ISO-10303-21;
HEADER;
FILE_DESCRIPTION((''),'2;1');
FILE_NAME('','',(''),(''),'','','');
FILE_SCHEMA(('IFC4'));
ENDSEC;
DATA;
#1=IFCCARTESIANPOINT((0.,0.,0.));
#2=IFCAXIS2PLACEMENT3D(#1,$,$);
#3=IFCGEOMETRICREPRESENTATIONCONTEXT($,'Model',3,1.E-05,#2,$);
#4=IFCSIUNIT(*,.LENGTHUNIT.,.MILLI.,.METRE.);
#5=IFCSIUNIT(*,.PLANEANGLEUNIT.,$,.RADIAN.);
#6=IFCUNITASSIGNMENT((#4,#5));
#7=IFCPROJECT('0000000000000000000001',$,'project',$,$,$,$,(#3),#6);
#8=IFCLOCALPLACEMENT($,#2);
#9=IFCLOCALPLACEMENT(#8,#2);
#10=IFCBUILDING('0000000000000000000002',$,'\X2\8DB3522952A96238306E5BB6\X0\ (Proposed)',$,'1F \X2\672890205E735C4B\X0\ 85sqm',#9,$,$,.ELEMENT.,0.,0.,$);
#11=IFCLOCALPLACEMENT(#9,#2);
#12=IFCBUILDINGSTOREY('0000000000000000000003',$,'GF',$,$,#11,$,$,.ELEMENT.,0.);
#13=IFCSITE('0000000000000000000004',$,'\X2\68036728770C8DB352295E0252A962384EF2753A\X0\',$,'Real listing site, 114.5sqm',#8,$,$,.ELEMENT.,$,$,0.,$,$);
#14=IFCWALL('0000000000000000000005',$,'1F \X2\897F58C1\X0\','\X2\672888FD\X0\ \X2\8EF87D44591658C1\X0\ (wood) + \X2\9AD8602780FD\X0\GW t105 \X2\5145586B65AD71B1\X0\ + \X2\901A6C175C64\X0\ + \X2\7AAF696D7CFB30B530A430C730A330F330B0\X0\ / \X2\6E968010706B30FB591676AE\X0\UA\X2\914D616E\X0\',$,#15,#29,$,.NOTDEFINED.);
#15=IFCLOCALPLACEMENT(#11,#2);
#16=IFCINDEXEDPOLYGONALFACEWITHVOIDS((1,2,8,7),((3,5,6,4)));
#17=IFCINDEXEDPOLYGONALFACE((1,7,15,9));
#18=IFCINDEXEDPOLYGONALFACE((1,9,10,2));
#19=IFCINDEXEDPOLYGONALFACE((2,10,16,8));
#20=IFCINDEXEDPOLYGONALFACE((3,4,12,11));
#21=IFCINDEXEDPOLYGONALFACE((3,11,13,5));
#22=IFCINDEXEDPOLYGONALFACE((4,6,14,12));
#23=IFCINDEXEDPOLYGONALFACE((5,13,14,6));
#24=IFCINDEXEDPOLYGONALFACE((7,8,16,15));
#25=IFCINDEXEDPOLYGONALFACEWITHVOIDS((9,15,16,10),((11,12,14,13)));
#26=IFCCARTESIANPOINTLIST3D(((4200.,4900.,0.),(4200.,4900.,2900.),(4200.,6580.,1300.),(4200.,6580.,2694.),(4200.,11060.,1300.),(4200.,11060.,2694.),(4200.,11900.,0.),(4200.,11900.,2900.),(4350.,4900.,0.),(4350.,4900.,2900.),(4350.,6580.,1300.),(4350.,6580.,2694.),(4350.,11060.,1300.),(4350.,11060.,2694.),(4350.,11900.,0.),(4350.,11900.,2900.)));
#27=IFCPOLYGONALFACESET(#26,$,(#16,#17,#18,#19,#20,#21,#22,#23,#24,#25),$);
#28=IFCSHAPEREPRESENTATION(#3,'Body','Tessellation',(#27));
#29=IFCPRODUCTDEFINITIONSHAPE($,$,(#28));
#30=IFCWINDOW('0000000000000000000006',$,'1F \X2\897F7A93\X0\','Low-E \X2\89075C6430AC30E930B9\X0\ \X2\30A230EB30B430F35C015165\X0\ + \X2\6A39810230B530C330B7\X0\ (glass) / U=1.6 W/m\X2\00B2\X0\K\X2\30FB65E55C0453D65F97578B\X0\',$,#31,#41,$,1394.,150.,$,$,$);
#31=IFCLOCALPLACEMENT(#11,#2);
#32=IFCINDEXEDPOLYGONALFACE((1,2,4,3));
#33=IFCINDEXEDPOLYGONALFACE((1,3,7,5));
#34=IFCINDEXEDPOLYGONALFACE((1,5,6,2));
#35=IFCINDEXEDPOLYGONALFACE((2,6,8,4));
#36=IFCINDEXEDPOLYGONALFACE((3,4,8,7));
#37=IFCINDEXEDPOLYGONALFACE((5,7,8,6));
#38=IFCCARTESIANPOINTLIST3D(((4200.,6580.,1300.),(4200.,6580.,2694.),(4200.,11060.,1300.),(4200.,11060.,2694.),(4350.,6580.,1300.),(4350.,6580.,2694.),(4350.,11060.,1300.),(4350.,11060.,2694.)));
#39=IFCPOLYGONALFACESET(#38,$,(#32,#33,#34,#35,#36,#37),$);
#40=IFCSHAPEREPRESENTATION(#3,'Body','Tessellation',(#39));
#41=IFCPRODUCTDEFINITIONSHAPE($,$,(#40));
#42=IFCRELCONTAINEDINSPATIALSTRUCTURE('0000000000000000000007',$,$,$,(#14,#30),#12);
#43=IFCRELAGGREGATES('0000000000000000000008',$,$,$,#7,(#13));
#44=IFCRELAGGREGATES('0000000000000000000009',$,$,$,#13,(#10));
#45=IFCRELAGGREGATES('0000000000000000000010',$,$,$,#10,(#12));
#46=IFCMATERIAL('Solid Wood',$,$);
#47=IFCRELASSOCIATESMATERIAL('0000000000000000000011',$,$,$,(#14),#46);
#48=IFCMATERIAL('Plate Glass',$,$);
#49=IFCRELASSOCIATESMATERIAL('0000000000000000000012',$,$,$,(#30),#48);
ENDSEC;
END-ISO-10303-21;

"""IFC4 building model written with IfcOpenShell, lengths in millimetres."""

from ifc_helpers import new_model, si_unit, frame, frame_2d, origin, place, context, project, spatial, rectangle, extrude, material, element, fill, save


model = new_model("IFC4")

# Units and contexts
model_context = context("Model", 3, precision=1e-05, world=origin())
ifc_project = project(units=[si_unit("LENGTHUNIT", "METRE", prefix="MILLI"), si_unit("PLANEANGLEUNIT", "RADIAN")], contexts=[model_context])

# Site, building, storey
site_placement = place(None, origin())
site = spatial("IfcSite", under=ifc_project, at=site_placement, Name="栃木県足利市助戸仲町", ObjectType="Real listing site, 114.5sqm", CompositionType="ELEMENT", RefElevation=0.0)
building_placement = place(site_placement, origin())
building = spatial("IfcBuilding", under=site, at=building_placement, Name="足利助戸の家 (Proposed)", ObjectType="1F 木造平屋 85sqm", CompositionType="ELEMENT", ElevationOfRefHeight=0.0, ElevationOfTerrain=0.0)
storey_placement = place(building_placement, origin())
storey = spatial("IfcBuildingStorey", under=building, at=storey_placement, Name="GF", CompositionType="ELEMENT", Elevation=0.0)

# Shared definitions
ifc_material_1 = material(Name="Solid Wood")

# Shared definitions
ifc_material_2 = material(Name="Plate Glass")

# Wall, opening, window
wall_1_placement = place(storey_placement, frame((2100.0, 2450.0, 0.0)))
wall_1 = element("IfcWall", 1, at=wall_1_placement, inside=storey, material=ifc_material_1, Name="1F 西壁", Description="木製 軸組外壁 (wood) + 高性能GW t105 充填断熱 + 通気層 + 窯業系サイディング / 準耐火・外皮UA配慮", PredefinedType="NOTDEFINED", context=model_context, shape_type="SweptSolid", body=[
    extrude(rectangle(XDim=150.0, YDim=7000.0, at=frame_2d((75.0, 3500.0))), frame((2100.0, 2450.0, 0.0)), (0.0, 0.0, 1.0), 2900.0),
])
opening_1_placement = place(storey_placement, frame((2100.0, 3290.0, 650.0)))
opening_1 = element("IfcOpeningElement", 2, at=opening_1_placement, cuts=wall_1, PredefinedType="NOTDEFINED", context=model_context, shape_type="SweptSolid", body=[
    extrude(rectangle(XDim=150.0, YDim=4480.0, at=frame_2d((75.0, 2240.0))), frame((2100.0, 3290.0, 650.0)), (0.0, 0.0, 1.0), 1394.0),
])
window_1_placement = place(storey_placement, frame((2100.0, 3290.0, 650.0)))
window_1 = element("IfcWindow", 3, at=window_1_placement, inside=storey, material=ifc_material_2, Name="1F 西窓", Description="Low-E 複層ガラス アルゴン封入 + 樹脂サッシ (glass) / U=1.6 W/m²K・日射取得型", OverallHeight=1394.0, OverallWidth=150.0, context=model_context, shape_type="SweptSolid", body=[
    extrude(rectangle(XDim=150.0, YDim=4480.0, at=frame_2d((75.0, 2240.0))), frame((2100.0, 3290.0, 650.0)), (0.0, 0.0, 1.0), 1394.0),
])
fill(opening_1, window_1)

save(model, "model.ifc")
